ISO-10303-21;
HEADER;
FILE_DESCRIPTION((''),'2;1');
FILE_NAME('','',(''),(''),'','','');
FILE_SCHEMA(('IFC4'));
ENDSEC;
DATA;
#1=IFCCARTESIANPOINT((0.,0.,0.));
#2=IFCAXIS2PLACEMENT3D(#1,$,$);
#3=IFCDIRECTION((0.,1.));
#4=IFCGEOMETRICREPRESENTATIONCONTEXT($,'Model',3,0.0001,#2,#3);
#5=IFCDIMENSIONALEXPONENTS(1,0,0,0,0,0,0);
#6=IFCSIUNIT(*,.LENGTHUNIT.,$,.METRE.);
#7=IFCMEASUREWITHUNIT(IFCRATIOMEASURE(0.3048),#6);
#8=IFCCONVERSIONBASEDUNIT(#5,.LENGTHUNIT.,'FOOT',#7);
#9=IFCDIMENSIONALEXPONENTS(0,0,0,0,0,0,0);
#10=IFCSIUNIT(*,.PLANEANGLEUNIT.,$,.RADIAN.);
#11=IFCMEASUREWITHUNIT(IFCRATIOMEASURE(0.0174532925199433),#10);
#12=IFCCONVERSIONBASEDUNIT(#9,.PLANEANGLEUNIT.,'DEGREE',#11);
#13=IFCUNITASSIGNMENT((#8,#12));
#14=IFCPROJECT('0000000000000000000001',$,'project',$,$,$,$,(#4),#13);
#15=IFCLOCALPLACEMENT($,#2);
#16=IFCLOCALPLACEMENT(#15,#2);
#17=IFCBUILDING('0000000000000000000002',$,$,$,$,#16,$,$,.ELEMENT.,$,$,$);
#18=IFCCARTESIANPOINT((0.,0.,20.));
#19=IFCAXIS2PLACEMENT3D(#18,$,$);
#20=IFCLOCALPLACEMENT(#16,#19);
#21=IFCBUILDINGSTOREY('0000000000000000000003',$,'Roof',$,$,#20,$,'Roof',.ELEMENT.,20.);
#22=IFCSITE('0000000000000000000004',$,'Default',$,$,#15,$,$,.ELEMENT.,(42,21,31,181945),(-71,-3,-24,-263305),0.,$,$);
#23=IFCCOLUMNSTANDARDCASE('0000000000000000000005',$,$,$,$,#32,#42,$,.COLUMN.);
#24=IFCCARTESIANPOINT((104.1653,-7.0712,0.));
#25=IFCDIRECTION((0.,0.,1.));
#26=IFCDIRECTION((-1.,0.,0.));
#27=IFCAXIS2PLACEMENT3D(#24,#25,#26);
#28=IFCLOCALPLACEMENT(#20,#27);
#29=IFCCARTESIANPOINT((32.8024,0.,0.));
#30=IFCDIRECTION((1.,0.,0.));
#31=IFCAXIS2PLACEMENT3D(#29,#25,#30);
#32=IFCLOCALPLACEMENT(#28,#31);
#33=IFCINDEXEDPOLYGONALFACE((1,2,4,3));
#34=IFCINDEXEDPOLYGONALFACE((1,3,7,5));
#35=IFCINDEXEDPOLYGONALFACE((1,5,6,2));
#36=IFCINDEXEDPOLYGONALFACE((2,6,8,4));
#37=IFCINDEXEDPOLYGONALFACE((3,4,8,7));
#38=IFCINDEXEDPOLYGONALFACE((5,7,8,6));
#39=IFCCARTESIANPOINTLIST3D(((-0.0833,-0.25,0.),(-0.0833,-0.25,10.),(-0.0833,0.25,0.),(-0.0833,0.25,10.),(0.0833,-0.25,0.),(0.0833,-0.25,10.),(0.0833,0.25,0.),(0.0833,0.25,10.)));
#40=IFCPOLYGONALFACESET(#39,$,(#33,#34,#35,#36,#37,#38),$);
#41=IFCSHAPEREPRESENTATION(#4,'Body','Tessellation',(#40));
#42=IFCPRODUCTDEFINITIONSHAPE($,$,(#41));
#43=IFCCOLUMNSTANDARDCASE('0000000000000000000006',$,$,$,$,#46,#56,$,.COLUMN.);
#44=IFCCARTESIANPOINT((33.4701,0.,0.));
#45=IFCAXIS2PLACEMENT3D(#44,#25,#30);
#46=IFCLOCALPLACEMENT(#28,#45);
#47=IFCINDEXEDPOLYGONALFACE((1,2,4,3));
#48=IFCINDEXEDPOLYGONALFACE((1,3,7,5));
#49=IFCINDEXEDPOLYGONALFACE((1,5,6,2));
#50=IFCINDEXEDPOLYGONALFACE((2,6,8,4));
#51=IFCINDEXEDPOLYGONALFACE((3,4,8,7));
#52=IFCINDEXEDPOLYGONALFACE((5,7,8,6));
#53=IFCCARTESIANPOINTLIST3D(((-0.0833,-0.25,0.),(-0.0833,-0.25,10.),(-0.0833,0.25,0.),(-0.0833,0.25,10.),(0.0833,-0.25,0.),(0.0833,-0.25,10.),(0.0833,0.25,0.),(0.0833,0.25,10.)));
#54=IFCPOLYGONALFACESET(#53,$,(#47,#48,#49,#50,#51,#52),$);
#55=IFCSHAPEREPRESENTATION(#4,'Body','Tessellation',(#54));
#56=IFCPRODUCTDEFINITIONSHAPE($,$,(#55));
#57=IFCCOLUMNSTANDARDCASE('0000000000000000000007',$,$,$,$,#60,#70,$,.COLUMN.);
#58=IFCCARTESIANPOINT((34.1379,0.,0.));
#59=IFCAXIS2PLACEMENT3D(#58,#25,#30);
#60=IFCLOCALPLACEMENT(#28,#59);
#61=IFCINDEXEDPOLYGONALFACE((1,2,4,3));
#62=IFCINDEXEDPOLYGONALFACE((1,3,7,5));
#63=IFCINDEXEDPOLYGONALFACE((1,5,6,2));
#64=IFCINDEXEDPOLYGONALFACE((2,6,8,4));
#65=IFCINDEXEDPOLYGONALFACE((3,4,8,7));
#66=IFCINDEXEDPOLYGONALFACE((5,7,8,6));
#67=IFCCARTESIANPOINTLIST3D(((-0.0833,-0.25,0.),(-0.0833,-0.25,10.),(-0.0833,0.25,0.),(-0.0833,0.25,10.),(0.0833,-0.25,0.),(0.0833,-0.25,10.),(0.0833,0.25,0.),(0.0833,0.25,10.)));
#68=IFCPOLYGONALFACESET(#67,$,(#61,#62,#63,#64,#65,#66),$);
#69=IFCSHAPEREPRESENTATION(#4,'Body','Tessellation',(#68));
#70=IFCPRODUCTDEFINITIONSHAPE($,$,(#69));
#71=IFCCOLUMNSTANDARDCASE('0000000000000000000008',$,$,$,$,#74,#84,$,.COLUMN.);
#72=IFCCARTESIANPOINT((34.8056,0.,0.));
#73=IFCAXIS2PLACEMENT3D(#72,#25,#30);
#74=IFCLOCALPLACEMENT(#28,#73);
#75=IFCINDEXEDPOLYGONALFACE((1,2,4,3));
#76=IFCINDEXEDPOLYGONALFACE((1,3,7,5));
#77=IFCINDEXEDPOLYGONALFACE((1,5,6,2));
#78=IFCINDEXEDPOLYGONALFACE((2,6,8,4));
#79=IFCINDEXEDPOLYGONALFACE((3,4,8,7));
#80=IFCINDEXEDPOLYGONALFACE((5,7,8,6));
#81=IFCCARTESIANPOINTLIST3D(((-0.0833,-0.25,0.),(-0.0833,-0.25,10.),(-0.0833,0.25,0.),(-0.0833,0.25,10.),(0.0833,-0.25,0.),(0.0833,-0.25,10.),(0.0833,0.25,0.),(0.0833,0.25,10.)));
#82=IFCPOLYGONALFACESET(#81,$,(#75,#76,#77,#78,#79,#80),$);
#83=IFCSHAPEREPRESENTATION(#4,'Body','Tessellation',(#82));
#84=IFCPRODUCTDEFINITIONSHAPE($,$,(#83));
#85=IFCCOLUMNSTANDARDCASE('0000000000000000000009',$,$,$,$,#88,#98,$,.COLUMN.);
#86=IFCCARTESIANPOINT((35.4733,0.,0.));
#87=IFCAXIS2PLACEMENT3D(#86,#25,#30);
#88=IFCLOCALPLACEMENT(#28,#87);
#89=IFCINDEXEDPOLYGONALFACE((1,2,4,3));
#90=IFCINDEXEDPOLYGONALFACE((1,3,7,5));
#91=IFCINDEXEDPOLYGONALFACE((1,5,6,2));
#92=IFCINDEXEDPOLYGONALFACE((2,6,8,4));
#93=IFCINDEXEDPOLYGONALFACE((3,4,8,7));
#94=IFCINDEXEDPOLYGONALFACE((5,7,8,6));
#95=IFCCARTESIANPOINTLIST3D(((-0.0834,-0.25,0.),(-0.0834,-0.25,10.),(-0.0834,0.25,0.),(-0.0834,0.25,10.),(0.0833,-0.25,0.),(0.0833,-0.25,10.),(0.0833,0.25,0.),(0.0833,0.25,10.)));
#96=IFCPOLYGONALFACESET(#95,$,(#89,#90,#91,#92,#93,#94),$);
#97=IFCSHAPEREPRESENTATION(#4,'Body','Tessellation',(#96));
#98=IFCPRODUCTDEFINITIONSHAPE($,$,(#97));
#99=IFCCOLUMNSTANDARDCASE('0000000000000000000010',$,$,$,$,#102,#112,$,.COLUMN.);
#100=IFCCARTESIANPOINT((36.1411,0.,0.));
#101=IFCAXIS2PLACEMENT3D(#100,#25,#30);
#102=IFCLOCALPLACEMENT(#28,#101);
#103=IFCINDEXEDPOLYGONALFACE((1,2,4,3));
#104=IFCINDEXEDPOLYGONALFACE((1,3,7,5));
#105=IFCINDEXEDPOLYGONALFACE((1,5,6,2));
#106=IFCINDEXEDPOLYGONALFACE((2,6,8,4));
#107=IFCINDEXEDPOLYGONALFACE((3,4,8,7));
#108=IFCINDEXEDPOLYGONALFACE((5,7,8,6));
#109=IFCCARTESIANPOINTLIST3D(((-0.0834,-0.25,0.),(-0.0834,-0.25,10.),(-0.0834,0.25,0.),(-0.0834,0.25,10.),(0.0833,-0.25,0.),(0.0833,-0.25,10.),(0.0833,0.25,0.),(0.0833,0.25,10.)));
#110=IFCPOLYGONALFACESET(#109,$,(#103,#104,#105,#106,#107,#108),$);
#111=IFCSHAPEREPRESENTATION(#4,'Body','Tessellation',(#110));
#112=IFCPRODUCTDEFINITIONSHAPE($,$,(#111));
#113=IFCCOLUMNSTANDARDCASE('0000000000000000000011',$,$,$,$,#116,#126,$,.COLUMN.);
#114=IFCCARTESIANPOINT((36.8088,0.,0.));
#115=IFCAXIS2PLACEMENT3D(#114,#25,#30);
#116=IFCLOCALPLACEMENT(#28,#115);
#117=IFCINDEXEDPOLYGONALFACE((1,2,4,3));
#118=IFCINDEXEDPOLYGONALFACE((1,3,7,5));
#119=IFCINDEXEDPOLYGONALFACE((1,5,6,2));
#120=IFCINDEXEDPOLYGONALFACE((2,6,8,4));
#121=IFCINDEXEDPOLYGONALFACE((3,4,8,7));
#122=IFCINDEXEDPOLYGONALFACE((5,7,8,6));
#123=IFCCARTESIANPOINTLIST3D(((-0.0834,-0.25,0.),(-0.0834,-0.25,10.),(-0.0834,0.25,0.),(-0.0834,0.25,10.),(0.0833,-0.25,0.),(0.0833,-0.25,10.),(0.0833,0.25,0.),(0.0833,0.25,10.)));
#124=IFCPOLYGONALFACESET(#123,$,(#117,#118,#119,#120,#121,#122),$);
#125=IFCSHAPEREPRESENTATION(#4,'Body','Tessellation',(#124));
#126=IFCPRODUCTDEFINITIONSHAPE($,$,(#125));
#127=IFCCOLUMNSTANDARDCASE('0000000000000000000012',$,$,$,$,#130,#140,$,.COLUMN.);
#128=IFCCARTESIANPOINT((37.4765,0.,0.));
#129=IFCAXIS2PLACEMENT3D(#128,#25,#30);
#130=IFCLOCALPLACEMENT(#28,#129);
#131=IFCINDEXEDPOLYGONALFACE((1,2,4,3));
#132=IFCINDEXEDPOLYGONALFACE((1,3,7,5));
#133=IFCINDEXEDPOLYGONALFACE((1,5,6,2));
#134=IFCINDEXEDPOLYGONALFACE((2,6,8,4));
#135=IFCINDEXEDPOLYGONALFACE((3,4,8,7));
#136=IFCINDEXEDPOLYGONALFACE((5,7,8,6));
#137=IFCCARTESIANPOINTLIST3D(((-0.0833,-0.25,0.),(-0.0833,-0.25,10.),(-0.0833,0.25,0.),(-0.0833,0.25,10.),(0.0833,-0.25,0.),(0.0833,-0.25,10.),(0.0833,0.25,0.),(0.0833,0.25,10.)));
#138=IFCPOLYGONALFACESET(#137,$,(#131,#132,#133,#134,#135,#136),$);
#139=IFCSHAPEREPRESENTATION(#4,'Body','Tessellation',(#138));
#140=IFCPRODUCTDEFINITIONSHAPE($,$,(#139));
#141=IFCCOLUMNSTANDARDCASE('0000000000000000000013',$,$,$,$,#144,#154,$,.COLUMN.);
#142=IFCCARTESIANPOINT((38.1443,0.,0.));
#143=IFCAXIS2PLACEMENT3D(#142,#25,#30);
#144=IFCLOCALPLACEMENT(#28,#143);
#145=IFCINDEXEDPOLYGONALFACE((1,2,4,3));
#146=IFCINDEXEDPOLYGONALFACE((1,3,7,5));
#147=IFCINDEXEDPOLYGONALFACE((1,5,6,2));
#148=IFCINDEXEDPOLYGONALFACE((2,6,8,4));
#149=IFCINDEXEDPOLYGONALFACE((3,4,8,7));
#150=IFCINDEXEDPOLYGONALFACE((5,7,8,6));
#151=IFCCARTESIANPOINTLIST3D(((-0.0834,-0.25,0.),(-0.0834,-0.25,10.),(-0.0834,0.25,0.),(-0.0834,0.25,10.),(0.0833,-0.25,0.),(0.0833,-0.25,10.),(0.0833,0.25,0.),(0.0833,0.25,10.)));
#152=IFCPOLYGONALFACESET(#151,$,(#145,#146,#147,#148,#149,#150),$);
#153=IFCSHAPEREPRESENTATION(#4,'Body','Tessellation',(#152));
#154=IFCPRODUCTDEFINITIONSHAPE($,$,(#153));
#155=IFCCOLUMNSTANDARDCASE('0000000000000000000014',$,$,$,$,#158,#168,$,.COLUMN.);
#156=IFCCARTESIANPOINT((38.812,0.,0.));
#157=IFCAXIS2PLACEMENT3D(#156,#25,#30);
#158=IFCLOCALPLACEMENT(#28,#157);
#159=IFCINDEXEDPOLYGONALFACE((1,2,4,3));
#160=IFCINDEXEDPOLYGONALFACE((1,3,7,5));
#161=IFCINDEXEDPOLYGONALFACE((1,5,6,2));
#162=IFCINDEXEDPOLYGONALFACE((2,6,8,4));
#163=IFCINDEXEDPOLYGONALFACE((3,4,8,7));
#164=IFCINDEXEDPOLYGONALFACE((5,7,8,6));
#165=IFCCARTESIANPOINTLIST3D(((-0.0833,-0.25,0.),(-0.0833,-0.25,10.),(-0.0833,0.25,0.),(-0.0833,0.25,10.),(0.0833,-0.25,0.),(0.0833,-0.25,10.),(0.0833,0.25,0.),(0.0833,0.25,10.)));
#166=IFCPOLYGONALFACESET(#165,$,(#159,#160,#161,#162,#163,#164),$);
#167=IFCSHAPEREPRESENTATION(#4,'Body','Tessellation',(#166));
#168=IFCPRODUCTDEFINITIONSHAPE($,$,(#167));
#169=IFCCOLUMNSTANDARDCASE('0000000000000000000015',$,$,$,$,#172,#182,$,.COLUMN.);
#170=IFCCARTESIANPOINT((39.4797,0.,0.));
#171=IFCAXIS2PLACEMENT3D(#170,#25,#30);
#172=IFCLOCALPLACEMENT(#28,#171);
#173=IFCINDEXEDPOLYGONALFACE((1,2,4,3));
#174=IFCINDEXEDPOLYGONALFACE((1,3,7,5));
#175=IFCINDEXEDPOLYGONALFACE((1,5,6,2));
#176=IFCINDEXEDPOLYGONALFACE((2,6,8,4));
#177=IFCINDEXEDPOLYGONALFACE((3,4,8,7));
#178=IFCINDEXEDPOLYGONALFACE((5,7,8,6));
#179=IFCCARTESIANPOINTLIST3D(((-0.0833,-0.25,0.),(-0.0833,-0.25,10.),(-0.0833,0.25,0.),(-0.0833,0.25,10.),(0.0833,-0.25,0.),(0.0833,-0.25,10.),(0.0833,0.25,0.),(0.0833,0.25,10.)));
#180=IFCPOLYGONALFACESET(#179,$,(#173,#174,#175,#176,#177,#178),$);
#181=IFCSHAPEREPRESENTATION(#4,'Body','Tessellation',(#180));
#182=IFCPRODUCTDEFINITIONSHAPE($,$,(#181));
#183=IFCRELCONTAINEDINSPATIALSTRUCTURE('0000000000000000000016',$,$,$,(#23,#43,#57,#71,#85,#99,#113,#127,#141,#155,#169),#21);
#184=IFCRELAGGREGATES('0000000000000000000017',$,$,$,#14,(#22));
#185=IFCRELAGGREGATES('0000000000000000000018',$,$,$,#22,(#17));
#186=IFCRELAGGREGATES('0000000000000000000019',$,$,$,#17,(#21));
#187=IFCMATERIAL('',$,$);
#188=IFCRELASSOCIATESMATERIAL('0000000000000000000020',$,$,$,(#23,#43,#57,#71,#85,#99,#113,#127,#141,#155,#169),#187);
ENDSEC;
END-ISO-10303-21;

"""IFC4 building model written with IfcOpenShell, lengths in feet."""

from ifc_helpers import new_model, entity, si_unit, converted_unit, direction, frame, origin, place, context, project, spatial, rectangle, extrude, material, element, save


model = new_model("IFC4")

# Units and contexts
model_context = context("Model", 3, precision=0.0001, world=origin(), true_north=direction((0.0, 1.0)))
ifc_project = project(units=[converted_unit("LENGTHUNIT", "FOOT", entity("IfcRatioMeasure", 0.3048), si_unit("LENGTHUNIT", "METRE"), dimensions=[1, 0, 0, 0, 0, 0, 0]), converted_unit("PLANEANGLEUNIT", "DEGREE", entity("IfcRatioMeasure", 0.0174532925199433), si_unit("PLANEANGLEUNIT", "RADIAN"), dimensions=[0, 0, 0, 0, 0, 0, 0])], contexts=[model_context])

# Site, building, storey
site_placement = place(None, origin())
site = spatial("IfcSite", under=ifc_project, at=site_placement, Name="Default", CompositionType="ELEMENT", RefLatitude=(42, 21, 31, 181945), RefLongitude=(-71, -3, -24, -263305), RefElevation=0.0)
building_placement = place(site_placement, origin())
building = spatial("IfcBuilding", under=site, at=building_placement, CompositionType="ELEMENT")
storey_placement = place(building_placement, frame((0.0, 0.0, 20.0)))
storey = spatial("IfcBuildingStorey", under=building, at=storey_placement, Name="Roof", LongName="Roof", CompositionType="ELEMENT", Elevation=20.0)

# Columns
ifc_material_1 = material(Name="")
placement_1 = place(storey_placement, frame((104.1653, -7.0712, 0.0), z_axis=(0.0, 0.0, 1.0), x_axis=(-1.0, 0.0, 0.0)))
for number, where, z_axis, x_axis in (
    (1, (32.8024, 0.0, 0.0), (0.0, 0.0, 1.0), (1.0, 0.0, 0.0)),
    (2, (33.4701, 0.0, 0.0), (0.0, 0.0, 1.0), (1.0, 0.0, 0.0)),
    (3, (34.1379, 0.0, 0.0), (0.0, 0.0, 1.0), (1.0, 0.0, 0.0)),
    (4, (34.8056, 0.0, 0.0), (0.0, 0.0, 1.0), (1.0, 0.0, 0.0)),
    (5, (35.4733, 0.0, 0.0), (0.0, 0.0, 1.0), (1.0, 0.0, 0.0)),
    (6, (36.1411, 0.0, 0.0), (0.0, 0.0, 1.0), (1.0, 0.0, 0.0)),
    (7, (36.8088, 0.0, 0.0), (0.0, 0.0, 1.0), (1.0, 0.0, 0.0)),
    (8, (37.4765, 0.0, 0.0), (0.0, 0.0, 1.0), (1.0, 0.0, 0.0)),
    (9, (38.1443, 0.0, 0.0), (0.0, 0.0, 1.0), (1.0, 0.0, 0.0)),
    (10, (38.812, 0.0, 0.0), (0.0, 0.0, 1.0), (1.0, 0.0, 0.0)),
    (11, (39.4797, 0.0, 0.0), (0.0, 0.0, 1.0), (1.0, 0.0, 0.0)),
):
    element("IfcColumnStandardCase", number, at=place(placement_1, frame(where, z_axis=z_axis, x_axis=x_axis)), inside=storey, material=ifc_material_1, PredefinedType="COLUMN", context=model_context, shape_type="SweptSolid", body=[
        extrude(rectangle(XDim=0.1667, YDim=0.5), origin(), (0.0, 0.0, 1.0), 10.0),
    ])

save(model, "model.ifc")
